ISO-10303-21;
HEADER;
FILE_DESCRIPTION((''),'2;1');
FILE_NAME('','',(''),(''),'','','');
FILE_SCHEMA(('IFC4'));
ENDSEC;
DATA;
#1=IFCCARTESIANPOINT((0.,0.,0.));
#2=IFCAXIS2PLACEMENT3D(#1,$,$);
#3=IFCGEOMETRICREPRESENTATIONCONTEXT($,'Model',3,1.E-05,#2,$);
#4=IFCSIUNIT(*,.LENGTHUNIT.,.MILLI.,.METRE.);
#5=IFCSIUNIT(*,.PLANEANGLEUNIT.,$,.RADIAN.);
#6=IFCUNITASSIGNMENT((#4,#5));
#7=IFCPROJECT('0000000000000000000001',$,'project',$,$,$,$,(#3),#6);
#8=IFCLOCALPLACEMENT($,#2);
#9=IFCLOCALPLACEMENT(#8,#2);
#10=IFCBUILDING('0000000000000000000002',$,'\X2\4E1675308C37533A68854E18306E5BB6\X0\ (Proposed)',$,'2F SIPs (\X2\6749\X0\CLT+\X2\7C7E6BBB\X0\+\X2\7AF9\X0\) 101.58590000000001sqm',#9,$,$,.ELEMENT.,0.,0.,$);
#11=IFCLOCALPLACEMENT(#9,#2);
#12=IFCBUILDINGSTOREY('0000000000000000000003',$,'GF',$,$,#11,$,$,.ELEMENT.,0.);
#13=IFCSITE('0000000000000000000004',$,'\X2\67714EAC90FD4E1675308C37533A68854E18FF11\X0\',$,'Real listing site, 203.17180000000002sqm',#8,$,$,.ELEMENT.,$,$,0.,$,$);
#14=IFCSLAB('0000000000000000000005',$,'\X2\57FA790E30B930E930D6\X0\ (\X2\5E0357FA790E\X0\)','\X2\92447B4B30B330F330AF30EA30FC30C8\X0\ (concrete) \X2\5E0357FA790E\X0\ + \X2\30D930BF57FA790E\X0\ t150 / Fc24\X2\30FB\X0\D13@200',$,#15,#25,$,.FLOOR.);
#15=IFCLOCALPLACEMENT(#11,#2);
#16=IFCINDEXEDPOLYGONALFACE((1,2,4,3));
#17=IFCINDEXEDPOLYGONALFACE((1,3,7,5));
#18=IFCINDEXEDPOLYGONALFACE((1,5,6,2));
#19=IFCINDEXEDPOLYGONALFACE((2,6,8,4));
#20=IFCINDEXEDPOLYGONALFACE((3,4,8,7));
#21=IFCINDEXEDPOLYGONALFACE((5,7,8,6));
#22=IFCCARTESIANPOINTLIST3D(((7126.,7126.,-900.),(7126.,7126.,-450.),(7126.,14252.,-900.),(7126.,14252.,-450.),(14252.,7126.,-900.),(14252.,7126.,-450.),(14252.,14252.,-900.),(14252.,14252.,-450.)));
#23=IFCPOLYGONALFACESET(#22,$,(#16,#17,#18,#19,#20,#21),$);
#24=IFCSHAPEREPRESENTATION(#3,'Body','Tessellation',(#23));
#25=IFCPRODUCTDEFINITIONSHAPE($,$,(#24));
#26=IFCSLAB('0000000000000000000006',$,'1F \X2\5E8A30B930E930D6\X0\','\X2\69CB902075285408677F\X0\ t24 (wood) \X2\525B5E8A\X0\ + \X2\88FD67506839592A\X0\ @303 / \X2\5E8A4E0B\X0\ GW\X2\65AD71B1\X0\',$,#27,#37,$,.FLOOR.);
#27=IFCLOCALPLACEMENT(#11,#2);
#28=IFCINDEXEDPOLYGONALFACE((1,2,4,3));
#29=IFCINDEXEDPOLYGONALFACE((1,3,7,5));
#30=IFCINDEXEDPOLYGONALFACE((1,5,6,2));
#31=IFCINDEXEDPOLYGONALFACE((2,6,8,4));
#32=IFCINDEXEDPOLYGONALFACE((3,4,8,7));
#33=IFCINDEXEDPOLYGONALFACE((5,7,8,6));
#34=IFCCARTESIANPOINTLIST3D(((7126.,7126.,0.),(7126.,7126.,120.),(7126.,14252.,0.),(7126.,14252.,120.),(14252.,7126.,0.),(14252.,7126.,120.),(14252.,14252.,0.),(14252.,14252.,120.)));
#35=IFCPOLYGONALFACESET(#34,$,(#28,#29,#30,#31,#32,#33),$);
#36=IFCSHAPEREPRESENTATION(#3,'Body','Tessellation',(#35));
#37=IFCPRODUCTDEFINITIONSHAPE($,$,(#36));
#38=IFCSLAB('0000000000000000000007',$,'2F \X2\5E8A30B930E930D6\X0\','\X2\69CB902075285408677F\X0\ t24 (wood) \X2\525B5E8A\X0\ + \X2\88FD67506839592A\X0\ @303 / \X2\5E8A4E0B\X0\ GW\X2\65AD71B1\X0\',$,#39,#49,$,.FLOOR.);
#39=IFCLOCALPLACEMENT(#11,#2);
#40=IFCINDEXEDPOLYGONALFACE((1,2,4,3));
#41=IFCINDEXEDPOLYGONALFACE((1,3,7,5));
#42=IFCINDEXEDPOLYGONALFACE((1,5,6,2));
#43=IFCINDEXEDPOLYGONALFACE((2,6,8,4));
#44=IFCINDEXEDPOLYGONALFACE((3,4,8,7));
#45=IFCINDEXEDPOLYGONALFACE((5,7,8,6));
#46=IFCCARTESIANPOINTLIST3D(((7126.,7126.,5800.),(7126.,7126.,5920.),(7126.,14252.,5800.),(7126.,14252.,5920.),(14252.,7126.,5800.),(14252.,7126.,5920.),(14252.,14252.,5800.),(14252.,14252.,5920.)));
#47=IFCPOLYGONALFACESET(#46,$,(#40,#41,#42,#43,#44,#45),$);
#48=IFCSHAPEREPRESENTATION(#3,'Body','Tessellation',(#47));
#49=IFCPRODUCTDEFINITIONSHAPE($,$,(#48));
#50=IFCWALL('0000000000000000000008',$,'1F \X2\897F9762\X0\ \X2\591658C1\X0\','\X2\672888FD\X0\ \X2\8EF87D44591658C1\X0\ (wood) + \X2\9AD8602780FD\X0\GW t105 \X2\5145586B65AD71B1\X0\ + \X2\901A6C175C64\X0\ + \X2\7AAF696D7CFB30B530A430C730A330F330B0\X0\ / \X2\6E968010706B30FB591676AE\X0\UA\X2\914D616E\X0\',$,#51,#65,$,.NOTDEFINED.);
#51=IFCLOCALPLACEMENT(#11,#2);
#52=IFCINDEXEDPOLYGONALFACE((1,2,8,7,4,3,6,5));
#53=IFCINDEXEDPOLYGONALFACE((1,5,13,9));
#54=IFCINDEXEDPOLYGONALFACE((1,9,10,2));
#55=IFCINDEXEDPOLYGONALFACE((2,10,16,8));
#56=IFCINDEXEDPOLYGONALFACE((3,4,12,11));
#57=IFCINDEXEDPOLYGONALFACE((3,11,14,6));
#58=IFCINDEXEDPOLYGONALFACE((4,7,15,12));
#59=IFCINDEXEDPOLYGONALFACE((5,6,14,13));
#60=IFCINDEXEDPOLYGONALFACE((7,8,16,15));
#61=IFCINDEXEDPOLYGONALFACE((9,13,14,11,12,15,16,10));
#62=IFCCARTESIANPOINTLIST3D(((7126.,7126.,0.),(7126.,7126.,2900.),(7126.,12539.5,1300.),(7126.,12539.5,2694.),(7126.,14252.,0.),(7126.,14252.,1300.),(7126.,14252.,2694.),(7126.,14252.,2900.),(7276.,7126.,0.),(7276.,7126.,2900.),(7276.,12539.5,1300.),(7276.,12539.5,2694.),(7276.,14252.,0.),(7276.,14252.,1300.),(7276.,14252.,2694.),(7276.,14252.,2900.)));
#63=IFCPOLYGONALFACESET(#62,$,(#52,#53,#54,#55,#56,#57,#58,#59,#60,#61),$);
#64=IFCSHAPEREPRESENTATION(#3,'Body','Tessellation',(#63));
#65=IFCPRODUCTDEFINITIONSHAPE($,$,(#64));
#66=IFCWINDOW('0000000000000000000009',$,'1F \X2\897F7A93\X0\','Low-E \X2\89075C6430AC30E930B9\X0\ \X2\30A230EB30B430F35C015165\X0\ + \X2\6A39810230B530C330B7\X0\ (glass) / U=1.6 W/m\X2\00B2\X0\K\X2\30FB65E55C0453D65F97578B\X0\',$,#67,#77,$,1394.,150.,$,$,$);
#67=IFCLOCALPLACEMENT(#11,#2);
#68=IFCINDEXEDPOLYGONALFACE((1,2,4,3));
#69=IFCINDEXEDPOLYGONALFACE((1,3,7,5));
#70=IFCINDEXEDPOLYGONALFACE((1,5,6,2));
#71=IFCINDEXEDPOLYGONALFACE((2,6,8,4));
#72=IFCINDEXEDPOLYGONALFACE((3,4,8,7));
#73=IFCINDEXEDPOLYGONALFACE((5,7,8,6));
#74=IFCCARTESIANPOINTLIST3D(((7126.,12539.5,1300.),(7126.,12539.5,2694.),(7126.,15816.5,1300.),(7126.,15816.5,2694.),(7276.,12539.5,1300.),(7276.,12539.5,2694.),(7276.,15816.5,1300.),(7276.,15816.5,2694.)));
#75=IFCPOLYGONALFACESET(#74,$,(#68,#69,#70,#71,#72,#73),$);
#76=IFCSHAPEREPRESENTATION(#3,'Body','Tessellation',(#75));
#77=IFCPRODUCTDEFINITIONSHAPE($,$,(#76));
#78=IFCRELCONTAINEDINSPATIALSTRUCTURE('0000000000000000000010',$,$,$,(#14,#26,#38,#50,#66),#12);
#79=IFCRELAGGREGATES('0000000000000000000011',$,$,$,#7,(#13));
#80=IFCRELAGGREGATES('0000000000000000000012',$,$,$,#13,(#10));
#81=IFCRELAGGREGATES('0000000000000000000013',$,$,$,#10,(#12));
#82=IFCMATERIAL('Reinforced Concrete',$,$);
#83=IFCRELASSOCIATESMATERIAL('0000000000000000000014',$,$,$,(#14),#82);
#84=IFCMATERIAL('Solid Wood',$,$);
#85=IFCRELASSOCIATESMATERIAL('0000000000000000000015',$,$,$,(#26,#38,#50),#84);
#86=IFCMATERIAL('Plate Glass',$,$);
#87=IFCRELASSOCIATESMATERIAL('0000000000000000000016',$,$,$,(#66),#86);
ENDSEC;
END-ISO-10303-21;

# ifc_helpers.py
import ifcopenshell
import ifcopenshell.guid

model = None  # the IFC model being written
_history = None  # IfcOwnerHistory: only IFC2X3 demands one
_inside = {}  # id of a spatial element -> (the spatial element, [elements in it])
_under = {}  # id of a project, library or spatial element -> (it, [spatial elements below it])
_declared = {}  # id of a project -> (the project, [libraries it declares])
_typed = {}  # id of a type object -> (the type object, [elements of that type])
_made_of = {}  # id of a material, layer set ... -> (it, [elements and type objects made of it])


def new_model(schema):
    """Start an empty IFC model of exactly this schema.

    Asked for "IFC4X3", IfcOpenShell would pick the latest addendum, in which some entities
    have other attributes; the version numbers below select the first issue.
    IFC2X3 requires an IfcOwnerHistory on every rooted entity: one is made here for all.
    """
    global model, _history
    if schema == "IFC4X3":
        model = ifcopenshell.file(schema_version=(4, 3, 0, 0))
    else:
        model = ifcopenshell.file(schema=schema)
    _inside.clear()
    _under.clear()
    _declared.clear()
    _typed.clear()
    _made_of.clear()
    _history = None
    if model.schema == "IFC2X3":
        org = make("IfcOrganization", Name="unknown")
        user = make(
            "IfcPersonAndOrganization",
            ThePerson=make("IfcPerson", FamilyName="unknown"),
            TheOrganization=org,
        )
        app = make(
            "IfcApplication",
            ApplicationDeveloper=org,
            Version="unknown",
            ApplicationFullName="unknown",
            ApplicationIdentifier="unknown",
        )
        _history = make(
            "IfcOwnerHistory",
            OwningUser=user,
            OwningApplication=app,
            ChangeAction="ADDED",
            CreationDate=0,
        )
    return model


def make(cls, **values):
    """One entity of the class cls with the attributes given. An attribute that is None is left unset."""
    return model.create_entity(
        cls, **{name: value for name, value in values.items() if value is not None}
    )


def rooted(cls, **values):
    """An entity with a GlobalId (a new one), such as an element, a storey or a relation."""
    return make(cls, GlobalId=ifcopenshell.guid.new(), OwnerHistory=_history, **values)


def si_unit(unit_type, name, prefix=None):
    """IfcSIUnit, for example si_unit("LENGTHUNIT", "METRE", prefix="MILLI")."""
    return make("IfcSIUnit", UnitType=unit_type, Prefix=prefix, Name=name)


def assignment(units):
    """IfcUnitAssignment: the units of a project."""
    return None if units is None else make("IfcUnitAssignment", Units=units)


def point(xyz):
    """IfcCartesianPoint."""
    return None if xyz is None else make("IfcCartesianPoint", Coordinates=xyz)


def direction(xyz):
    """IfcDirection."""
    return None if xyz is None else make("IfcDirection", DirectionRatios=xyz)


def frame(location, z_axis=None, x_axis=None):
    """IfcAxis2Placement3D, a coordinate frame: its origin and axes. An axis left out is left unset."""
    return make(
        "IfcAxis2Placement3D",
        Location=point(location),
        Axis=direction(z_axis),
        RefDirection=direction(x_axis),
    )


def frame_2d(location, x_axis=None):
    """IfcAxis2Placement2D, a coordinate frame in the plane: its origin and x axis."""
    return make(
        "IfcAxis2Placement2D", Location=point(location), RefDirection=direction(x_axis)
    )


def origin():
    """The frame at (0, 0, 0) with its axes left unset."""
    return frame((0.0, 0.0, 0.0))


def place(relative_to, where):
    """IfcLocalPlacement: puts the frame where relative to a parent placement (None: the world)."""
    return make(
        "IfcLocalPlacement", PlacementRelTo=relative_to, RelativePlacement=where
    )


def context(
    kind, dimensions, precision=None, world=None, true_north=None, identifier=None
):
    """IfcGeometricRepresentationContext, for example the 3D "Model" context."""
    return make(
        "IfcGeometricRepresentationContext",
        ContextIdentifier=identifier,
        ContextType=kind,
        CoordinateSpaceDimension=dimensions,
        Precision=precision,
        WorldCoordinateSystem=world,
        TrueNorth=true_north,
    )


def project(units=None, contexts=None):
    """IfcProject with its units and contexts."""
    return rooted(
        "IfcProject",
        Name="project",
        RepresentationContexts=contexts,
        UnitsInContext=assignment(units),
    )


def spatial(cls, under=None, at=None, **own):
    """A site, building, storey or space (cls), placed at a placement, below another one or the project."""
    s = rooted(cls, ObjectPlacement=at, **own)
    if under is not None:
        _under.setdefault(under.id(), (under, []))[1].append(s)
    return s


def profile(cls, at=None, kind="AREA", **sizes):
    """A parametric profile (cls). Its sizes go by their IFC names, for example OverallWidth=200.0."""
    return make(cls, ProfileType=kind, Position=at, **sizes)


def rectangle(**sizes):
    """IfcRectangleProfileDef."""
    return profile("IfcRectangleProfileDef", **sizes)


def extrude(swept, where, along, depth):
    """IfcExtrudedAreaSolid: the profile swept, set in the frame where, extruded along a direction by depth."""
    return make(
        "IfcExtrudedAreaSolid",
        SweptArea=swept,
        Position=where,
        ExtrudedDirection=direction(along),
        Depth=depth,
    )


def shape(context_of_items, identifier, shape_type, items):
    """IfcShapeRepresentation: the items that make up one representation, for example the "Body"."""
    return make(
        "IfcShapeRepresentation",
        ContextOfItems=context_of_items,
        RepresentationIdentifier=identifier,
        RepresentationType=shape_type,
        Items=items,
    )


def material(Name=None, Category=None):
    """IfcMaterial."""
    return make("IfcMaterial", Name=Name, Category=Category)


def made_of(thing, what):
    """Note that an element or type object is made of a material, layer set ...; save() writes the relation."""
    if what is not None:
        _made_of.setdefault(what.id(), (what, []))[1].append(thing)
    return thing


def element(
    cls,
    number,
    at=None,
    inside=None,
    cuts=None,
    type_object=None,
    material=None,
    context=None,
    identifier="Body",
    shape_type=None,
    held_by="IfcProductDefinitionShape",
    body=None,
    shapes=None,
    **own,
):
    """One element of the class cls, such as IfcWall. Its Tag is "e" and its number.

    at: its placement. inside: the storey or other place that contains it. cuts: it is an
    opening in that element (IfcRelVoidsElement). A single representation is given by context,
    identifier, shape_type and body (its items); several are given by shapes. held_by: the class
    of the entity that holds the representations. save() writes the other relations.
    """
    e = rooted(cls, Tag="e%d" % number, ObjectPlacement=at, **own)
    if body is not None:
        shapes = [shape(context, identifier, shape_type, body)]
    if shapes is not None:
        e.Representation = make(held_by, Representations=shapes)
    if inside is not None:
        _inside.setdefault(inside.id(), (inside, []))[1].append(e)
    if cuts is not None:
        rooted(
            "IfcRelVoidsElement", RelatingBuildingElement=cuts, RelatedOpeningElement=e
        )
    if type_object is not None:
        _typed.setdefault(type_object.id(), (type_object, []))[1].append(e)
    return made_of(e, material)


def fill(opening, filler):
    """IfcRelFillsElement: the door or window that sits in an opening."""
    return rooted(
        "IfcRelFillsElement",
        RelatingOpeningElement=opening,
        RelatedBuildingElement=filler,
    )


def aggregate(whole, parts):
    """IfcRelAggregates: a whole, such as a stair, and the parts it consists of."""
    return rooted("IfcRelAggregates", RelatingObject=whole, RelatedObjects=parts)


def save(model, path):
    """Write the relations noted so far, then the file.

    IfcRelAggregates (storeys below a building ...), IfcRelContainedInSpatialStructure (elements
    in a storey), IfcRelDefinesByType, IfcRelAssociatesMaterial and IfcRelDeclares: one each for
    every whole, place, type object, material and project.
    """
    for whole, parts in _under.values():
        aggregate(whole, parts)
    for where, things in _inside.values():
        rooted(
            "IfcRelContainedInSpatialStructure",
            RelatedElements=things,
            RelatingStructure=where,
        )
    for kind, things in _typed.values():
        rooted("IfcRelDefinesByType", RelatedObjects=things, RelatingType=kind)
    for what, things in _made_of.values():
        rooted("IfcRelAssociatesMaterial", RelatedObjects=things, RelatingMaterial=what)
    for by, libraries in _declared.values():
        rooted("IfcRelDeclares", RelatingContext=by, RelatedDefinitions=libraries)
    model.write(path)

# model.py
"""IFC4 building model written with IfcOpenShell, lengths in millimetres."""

from ifc_helpers import new_model, si_unit, frame, frame_2d, origin, place, context, project, spatial, rectangle, extrude, material, element, fill, save


model = new_model("IFC4")

# Units and contexts
model_context = context("Model", 3, precision=1e-05, world=origin())
ifc_project = project(units=[si_unit("LENGTHUNIT", "METRE", prefix="MILLI"), si_unit("PLANEANGLEUNIT", "RADIAN")], contexts=[model_context])

# Site, building, storey
site_placement = place(None, origin())
site = spatial("IfcSite", under=ifc_project, at=site_placement, Name="東京都世田谷区梅丘１", ObjectType="Real listing site, 203.17180000000002sqm", CompositionType="ELEMENT", RefElevation=0.0)
building_placement = place(site_placement, origin())
building = spatial("IfcBuilding", under=site, at=building_placement, Name="世田谷区梅丘の家 (Proposed)", ObjectType="2F SIPs (杉CLT+籾殻+竹) 101.58590000000001sqm", CompositionType="ELEMENT", ElevationOfRefHeight=0.0, ElevationOfTerrain=0.0)
storey_placement = place(building_placement, origin())
storey = spatial("IfcBuildingStorey", under=building, at=storey_placement, Name="GF", CompositionType="ELEMENT", Elevation=0.0)

# Slabs
ifc_material_1 = material(Name="Reinforced Concrete")
slab_1_placement = place(storey_placement, frame((3563.0, 3563.0, -450.0)))
element("IfcSlab", 1, at=slab_1_placement, inside=storey, material=ifc_material_1, Name="基礎スラブ (布基礎)", Description="鉄筋コンクリート (concrete) 布基礎 + ベタ基礎 t150 / Fc24・D13@200", PredefinedType="FLOOR", context=model_context, shape_type="SweptSolid", body=[
    extrude(rectangle(XDim=7126.0, YDim=7126.0, at=frame_2d((3563.0, 3563.0))), frame((3563.0, 3563.0, -450.0)), (0.0, 0.0, 1.0), 450.0),
])
ifc_material_2 = material(Name="Solid Wood")
slab_2_placement = place(storey_placement, frame((3563.0, 3563.0, 0.0)))
element("IfcSlab", 2, at=slab_2_placement, inside=storey, material=ifc_material_2, Name="1F 床スラブ", Description="構造用合板 t24 (wood) 剛床 + 製材根太 @303 / 床下 GW断熱", PredefinedType="FLOOR", context=model_context, shape_type="SweptSolid", body=[
    extrude(rectangle(XDim=7126.0, YDim=7126.0, at=frame_2d((3563.0, 3563.0))), frame((3563.0, 3563.0, 0.0)), (0.0, 0.0, 1.0), 120.0),
])
slab_3_placement = place(storey_placement, frame((3563.0, 3563.0, 2900.0)))
element("IfcSlab", 3, at=slab_3_placement, inside=storey, material=ifc_material_2, Name="2F 床スラブ", Description="構造用合板 t24 (wood) 剛床 + 製材根太 @303 / 床下 GW断熱", PredefinedType="FLOOR", context=model_context, shape_type="SweptSolid", body=[
    extrude(rectangle(XDim=7126.0, YDim=7126.0, at=frame_2d((3563.0, 3563.0))), frame((3563.0, 3563.0, 2900.0)), (0.0, 0.0, 1.0), 120.0),
])

# Shared definitions
ifc_material_3 = material(Name="Plate Glass")

# Wall, opening, window
wall_1_placement = place(storey_placement, frame((3563.0, 3563.0, 0.0)))
wall_1 = element("IfcWall", 4, at=wall_1_placement, inside=storey, material=ifc_material_2, Name="1F 西面 外壁", Description="木製 軸組外壁 (wood) + 高性能GW t105 充填断熱 + 通気層 + 窯業系サイディング / 準耐火・外皮UA配慮", PredefinedType="NOTDEFINED", context=model_context, shape_type="SweptSolid", body=[
    extrude(rectangle(XDim=150.0, YDim=7126.0, at=frame_2d((75.0, 3563.0))), frame((3563.0, 3563.0, 0.0)), (0.0, 0.0, 1.0), 2900.0),
])
opening_1_placement = place(storey_placement, frame((3563.0, 6270.0, 650.0)))
opening_1 = element("IfcOpeningElement", 5, at=opening_1_placement, cuts=wall_1, PredefinedType="NOTDEFINED", context=model_context, shape_type="SweptSolid", body=[
    extrude(rectangle(XDim=150.0, YDim=3277.0, at=frame_2d((75.0, 1638.0))), frame((3563.0, 6270.0, 650.0)), (0.0, 0.0, 1.0), 1394.0),
])
window_1_placement = place(storey_placement, frame((3563.0, 6270.0, 650.0)))
window_1 = element("IfcWindow", 6, at=window_1_placement, inside=storey, material=ifc_material_3, Name="1F 西窓", Description="Low-E 複層ガラス アルゴン封入 + 樹脂サッシ (glass) / U=1.6 W/m²K・日射取得型", OverallHeight=1394.0, OverallWidth=150.0, context=model_context, shape_type="SweptSolid", body=[
    extrude(rectangle(XDim=150.0, YDim=3277.0, at=frame_2d((75.0, 1638.0))), frame((3563.0, 6270.0, 650.0)), (0.0, 0.0, 1.0), 1394.0),
])
fill(opening_1, window_1)

save(model, "model.ifc")
